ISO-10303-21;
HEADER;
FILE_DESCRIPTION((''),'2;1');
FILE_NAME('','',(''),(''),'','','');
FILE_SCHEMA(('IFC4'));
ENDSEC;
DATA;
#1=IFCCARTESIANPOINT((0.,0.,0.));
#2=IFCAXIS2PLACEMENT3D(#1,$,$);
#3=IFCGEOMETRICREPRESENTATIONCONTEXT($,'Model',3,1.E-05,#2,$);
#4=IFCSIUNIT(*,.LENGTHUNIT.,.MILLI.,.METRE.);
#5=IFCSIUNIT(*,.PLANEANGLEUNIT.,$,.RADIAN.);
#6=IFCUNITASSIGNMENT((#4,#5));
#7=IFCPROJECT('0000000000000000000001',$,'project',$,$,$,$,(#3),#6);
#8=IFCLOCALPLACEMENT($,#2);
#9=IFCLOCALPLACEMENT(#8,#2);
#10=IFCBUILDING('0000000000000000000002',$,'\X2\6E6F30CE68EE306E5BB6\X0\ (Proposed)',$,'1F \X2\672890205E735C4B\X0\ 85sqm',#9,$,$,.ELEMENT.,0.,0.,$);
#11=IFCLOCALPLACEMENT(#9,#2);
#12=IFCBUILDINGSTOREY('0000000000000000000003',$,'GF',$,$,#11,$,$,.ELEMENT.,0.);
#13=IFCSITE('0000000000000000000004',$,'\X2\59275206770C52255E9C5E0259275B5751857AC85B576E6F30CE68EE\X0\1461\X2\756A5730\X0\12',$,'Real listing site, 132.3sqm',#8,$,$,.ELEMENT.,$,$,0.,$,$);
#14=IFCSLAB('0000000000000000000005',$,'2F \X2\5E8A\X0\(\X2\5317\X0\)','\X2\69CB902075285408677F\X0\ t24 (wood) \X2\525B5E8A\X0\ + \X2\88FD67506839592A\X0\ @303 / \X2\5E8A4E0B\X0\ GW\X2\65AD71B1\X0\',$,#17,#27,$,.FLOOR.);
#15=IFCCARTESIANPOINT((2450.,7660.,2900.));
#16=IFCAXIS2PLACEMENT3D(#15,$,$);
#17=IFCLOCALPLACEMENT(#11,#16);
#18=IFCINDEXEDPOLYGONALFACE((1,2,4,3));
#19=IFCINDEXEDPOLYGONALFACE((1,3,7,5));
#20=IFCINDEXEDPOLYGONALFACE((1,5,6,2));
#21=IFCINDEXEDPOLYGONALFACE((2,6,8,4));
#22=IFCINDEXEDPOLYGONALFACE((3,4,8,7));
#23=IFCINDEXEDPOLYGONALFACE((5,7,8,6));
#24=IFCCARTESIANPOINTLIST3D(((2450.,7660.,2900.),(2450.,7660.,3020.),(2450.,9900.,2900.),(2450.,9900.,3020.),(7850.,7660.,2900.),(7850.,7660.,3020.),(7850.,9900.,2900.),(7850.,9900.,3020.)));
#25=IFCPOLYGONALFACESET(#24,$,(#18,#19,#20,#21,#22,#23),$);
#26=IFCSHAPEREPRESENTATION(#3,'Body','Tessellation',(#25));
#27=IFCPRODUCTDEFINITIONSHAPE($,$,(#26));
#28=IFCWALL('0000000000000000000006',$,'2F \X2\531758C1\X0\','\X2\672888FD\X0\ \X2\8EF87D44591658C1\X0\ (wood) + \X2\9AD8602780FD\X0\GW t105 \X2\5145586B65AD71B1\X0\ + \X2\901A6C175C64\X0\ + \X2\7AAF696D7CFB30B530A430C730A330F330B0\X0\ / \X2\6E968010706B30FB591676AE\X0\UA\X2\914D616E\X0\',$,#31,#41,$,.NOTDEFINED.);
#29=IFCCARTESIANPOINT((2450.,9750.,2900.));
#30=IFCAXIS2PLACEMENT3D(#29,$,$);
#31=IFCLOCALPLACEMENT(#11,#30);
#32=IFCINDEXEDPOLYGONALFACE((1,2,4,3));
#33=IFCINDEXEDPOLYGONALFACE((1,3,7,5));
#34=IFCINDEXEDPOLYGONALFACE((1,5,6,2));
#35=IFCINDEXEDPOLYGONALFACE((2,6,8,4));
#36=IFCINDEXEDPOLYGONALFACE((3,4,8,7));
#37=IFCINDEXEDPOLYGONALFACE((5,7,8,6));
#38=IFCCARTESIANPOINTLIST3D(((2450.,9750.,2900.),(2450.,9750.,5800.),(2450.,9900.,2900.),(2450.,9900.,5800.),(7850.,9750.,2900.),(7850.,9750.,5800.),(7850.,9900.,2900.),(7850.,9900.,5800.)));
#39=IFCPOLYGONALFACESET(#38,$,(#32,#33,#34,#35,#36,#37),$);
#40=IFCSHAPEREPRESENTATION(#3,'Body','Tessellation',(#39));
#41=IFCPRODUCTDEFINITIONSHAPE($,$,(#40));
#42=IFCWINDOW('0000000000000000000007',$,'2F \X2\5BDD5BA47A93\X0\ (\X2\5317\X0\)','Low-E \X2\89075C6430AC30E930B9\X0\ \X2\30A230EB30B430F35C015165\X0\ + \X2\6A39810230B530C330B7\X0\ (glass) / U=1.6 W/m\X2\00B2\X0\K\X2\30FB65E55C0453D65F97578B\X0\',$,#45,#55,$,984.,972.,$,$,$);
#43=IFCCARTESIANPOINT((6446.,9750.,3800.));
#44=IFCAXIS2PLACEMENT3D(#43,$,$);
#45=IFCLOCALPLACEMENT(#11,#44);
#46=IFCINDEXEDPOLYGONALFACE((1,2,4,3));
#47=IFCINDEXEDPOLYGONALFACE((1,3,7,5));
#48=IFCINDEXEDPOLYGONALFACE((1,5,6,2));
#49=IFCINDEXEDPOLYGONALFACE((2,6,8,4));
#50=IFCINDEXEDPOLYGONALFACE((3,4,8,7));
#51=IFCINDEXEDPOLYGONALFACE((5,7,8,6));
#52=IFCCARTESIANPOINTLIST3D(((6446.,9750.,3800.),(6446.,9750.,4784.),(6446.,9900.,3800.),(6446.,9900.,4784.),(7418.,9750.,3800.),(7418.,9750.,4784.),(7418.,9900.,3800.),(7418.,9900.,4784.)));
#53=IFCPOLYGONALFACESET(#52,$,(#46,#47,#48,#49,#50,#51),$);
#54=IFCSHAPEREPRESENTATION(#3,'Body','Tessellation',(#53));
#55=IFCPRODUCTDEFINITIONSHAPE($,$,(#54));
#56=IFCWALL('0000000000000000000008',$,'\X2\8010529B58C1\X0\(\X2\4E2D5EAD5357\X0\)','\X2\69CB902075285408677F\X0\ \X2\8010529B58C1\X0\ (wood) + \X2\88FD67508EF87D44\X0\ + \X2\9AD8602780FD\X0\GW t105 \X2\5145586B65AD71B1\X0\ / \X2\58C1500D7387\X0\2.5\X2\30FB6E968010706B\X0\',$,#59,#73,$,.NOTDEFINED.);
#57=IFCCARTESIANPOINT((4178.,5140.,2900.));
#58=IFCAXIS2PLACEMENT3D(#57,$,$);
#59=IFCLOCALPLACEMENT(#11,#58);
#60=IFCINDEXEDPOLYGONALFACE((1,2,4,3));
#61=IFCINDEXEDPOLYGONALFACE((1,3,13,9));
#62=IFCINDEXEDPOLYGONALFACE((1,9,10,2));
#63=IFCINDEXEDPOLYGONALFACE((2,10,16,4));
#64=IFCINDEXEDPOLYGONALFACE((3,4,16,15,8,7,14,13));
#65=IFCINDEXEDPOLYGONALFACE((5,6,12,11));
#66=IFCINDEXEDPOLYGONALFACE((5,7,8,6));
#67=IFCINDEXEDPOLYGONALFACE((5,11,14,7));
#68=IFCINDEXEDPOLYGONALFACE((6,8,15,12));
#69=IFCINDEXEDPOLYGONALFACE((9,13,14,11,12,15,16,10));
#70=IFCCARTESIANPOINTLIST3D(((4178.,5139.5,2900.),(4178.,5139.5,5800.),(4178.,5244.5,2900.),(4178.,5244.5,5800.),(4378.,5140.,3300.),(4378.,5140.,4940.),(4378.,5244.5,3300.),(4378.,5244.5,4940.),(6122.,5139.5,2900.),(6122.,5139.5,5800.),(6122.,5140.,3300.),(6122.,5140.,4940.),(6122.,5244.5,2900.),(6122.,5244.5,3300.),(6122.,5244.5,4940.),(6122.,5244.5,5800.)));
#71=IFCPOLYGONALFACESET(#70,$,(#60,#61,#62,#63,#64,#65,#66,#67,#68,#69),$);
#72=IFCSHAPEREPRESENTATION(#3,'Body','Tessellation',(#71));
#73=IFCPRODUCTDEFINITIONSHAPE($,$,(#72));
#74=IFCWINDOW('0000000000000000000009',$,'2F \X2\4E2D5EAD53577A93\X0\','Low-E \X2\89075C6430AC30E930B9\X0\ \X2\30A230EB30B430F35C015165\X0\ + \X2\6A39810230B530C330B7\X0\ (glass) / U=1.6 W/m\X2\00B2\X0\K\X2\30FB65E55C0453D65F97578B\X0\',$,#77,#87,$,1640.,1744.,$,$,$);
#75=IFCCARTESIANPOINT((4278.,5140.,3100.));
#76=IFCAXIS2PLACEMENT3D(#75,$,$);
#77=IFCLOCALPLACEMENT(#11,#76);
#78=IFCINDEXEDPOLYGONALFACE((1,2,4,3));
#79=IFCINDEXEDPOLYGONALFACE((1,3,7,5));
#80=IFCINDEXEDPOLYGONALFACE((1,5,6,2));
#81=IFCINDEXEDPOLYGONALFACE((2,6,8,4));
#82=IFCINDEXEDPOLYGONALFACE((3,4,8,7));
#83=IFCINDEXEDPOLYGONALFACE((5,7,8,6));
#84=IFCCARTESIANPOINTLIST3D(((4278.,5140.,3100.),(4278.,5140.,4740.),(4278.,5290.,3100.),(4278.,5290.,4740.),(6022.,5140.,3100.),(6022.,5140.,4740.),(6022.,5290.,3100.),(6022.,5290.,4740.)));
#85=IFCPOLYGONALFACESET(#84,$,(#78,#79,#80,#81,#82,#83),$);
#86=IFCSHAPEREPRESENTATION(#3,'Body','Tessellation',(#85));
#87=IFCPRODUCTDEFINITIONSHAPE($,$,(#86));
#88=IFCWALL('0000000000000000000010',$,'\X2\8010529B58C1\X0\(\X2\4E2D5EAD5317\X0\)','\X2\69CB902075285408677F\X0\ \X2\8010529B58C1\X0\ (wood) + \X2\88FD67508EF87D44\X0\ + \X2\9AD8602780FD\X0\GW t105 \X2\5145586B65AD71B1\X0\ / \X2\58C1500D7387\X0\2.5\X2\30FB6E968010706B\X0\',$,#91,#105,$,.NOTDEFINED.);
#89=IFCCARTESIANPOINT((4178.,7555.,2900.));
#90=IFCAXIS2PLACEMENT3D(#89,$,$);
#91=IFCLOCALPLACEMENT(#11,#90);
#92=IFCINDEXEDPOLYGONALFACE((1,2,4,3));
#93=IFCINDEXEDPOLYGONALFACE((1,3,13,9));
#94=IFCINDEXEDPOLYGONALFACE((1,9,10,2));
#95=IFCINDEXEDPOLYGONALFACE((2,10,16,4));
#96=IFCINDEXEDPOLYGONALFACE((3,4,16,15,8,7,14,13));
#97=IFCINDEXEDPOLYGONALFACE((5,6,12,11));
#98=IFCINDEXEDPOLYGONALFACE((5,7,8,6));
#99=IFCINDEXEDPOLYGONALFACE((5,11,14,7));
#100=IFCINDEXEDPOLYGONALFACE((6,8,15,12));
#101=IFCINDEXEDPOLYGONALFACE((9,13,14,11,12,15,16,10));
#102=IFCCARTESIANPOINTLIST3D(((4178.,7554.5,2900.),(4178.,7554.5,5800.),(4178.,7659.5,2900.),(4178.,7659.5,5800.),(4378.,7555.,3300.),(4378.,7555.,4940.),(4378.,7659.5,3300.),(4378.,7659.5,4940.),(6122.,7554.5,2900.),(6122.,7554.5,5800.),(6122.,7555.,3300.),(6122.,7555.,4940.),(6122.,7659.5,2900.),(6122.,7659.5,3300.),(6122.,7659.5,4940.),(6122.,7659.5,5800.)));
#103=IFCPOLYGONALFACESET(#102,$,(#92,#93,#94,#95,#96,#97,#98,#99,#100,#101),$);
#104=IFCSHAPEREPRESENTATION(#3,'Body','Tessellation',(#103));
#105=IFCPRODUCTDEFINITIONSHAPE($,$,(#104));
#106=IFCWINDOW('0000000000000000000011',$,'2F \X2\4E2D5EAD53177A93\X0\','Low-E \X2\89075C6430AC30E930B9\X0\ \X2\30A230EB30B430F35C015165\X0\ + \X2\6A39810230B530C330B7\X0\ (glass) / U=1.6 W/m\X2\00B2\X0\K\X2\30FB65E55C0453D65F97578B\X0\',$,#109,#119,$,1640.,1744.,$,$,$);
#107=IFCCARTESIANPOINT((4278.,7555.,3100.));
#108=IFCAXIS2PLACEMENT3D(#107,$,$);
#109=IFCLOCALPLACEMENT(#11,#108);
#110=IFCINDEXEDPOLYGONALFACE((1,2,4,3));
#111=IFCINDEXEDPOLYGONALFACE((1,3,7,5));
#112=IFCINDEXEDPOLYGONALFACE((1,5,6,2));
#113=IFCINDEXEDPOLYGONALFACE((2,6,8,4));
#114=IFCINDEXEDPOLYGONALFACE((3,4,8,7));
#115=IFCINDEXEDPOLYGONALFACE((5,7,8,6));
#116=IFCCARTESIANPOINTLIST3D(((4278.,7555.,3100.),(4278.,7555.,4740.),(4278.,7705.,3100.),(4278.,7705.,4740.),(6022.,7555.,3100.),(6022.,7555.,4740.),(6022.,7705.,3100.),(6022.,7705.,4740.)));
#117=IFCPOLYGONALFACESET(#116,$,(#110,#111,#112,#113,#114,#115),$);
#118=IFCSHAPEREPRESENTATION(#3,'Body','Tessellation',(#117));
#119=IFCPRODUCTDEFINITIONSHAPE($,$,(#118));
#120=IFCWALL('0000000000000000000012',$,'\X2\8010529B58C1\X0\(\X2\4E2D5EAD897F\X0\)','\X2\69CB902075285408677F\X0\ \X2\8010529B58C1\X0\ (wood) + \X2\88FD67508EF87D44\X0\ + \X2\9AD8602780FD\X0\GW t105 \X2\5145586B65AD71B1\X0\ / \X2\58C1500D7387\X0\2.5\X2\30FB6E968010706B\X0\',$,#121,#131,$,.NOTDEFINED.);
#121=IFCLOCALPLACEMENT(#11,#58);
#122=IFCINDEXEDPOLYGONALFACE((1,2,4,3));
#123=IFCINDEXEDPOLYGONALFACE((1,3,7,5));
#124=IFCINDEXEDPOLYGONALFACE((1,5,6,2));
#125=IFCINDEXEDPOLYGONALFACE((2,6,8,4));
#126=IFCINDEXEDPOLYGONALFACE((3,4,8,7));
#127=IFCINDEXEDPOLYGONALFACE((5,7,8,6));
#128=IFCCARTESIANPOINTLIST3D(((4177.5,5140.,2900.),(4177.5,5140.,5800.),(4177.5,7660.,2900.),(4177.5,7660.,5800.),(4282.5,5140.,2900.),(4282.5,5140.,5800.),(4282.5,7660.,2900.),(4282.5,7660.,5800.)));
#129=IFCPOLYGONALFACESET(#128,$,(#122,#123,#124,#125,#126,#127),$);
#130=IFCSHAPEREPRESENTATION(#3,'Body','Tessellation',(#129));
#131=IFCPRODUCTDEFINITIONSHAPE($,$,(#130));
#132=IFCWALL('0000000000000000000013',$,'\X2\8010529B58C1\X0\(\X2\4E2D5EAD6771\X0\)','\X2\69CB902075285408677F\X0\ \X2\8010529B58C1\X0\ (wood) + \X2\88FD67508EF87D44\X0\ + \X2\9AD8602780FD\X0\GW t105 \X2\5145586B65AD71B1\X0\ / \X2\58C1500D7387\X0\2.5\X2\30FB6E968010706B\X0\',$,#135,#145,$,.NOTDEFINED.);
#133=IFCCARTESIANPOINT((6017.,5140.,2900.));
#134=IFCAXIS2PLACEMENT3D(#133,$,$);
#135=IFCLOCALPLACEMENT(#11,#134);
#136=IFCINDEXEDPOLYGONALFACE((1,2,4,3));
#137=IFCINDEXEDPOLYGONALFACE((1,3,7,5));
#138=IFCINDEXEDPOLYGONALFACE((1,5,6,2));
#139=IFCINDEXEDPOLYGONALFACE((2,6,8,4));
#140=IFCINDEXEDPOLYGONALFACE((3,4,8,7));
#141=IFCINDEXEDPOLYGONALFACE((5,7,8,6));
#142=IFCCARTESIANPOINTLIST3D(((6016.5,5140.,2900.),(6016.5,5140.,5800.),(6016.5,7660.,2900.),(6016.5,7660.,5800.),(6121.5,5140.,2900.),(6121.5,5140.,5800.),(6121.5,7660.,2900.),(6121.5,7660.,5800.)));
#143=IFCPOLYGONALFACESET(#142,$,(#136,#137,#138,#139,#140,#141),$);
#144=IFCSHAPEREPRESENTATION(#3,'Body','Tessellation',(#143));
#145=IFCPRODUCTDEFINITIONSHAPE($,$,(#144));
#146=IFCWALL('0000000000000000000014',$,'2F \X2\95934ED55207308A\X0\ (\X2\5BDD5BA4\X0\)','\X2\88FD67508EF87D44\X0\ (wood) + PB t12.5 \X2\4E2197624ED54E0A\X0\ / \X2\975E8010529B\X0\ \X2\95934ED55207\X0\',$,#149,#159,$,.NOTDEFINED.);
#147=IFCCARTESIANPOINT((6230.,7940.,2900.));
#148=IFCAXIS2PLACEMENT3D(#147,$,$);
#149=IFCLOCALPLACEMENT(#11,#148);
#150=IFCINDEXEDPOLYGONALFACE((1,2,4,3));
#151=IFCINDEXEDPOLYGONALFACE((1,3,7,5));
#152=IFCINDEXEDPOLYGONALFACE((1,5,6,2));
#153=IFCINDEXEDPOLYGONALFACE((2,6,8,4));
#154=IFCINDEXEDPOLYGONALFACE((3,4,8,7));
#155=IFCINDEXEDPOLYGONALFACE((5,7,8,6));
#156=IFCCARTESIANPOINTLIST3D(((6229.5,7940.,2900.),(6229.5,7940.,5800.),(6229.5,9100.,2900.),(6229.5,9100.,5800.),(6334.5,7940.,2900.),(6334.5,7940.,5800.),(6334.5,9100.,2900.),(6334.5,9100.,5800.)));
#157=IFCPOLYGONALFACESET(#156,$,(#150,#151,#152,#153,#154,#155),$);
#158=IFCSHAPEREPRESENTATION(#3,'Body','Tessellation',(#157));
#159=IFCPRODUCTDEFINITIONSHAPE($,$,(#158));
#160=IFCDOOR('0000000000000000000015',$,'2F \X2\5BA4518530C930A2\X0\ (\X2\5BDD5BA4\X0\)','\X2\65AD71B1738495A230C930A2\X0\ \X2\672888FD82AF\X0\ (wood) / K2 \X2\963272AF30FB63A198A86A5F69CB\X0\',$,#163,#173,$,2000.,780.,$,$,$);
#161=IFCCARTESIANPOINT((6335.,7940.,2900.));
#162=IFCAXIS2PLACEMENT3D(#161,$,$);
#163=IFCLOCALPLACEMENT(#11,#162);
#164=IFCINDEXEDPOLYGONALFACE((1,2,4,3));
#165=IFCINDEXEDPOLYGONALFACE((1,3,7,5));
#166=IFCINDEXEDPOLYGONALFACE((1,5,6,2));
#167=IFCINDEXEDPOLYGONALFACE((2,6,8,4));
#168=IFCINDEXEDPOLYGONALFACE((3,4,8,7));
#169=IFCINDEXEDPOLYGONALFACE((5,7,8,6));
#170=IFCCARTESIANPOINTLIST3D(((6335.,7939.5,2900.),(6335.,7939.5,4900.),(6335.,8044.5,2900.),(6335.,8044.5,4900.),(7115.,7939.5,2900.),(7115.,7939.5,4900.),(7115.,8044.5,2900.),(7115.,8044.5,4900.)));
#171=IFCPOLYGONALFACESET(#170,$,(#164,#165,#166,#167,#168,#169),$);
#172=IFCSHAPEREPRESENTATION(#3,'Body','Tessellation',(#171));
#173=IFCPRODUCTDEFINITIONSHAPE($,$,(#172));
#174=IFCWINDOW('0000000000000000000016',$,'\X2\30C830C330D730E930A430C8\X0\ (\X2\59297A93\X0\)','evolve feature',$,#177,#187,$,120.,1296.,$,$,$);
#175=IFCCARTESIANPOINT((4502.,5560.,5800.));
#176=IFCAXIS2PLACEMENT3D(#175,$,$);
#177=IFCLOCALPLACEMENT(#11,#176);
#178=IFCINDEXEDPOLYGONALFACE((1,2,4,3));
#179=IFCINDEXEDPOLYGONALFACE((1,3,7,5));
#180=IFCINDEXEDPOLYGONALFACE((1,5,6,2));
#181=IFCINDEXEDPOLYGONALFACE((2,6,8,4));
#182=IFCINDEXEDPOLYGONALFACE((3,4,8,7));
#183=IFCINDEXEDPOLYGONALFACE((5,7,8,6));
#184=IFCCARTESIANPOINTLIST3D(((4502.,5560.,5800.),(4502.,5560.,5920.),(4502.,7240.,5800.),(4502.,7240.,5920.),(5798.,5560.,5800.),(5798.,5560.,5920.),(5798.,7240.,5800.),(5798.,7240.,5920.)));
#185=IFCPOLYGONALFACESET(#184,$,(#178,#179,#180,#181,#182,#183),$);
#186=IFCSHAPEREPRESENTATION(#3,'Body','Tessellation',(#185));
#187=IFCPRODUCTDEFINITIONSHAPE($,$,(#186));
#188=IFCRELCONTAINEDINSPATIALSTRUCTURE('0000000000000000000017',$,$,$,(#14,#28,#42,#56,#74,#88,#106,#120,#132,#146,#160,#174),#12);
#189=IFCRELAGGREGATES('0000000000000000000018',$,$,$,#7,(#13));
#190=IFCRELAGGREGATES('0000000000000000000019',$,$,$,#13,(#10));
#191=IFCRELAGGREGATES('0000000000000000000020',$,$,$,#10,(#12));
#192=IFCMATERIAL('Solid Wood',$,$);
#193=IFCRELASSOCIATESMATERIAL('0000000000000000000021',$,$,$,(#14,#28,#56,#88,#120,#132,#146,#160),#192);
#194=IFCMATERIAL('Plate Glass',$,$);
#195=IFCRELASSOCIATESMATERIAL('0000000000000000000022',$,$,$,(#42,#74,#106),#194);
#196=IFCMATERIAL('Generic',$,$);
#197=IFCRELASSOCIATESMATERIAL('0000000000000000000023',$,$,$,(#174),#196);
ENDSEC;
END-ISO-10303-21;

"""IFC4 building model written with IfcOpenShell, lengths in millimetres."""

from ifc_helpers import new_model, si_unit, frame, frame_2d, origin, place, context, project, spatial, rectangle, extrude, material, element, fill, save


model = new_model("IFC4")

# Units and contexts
model_context = context("Model", 3, precision=1e-05, world=origin())
ifc_project = project(units=[si_unit("LENGTHUNIT", "METRE", prefix="MILLI"), si_unit("PLANEANGLEUNIT", "RADIAN")], contexts=[model_context])

# Site, building, storey
site_placement = place(None, origin())
site = spatial("IfcSite", under=ifc_project, at=site_placement, Name="大分県別府市大字内竈字湯ノ森1461番地12", ObjectType="Real listing site, 132.3sqm", CompositionType="ELEMENT", RefElevation=0.0)
building_placement = place(site_placement, origin())
building = spatial("IfcBuilding", under=site, at=building_placement, Name="湯ノ森の家 (Proposed)", ObjectType="1F 木造平屋 85sqm", CompositionType="ELEMENT", ElevationOfRefHeight=0.0, ElevationOfTerrain=0.0)
storey_placement = place(building_placement, origin())
storey = spatial("IfcBuildingStorey", under=building, at=storey_placement, Name="GF", CompositionType="ELEMENT", Elevation=0.0)

# Slab
ifc_material_1 = material(Name="Solid Wood")
slab_placement = place(storey_placement, frame((2450.0, 7660.0, 2900.0)))
element("IfcSlab", 1, at=slab_placement, inside=storey, material=ifc_material_1, Name="2F 床(北)", Description="構造用合板 t24 (wood) 剛床 + 製材根太 @303 / 床下 GW断熱", PredefinedType="FLOOR", context=model_context, shape_type="SweptSolid", body=[
    extrude(rectangle(XDim=5400.0, YDim=2240.0, at=frame_2d((2700.0, 1120.0))), frame((2450.0, 7660.0, 2900.0)), (0.0, 0.0, 1.0), 120.0),
])

# Walls, openings, windows
wall_1_placement = place(storey_placement, frame((2450.0, 9750.0, 2900.0)))
wall_1 = element("IfcWall", 2, at=wall_1_placement, inside=storey, material=ifc_material_1, Name="2F 北壁", Description="木製 軸組外壁 (wood) + 高性能GW t105 充填断熱 + 通気層 + 窯業系サイディング / 準耐火・外皮UA配慮", PredefinedType="NOTDEFINED", context=model_context, shape_type="SweptSolid", body=[
    extrude(rectangle(XDim=5400.0, YDim=150.0, at=frame_2d((2700.0, 75.0))), frame((2450.0, 9750.0, 2900.0)), (0.0, 0.0, 1.0), 2900.0),
])
opening_1_placement = place(storey_placement, frame((6446.0, 9750.0, 3800.0)))
opening_1 = element("IfcOpeningElement", 3, at=opening_1_placement, cuts=wall_1, PredefinedType="NOTDEFINED", context=model_context, shape_type="SweptSolid", body=[
    extrude(rectangle(XDim=972.0, YDim=150.0, at=frame_2d((486.0, 75.0))), frame((6446.0, 9750.0, 3800.0)), (0.0, 0.0, 1.0), 984.0),
])
ifc_material_2 = material(Name="Plate Glass")
window_1_placement = place(storey_placement, frame((6446.0, 9750.0, 3800.0)))
window_1 = element("IfcWindow", 4, at=window_1_placement, inside=storey, material=ifc_material_2, Name="2F 寝室窓 (北)", Description="Low-E 複層ガラス アルゴン封入 + 樹脂サッシ (glass) / U=1.6 W/m²K・日射取得型", OverallHeight=984.0, OverallWidth=972.0, context=model_context, shape_type="SweptSolid", body=[
    extrude(rectangle(XDim=972.0, YDim=150.0, at=frame_2d((486.0, 75.0))), frame((6446.0, 9750.0, 3800.0)), (0.0, 0.0, 1.0), 984.0),
])
fill(opening_1, window_1)
wall_2_placement = place(storey_placement, frame((4178.0, 5140.0, 2900.0)))
wall_2 = element("IfcWall", 5, at=wall_2_placement, inside=storey, material=ifc_material_1, Name="耐力壁(中庭南)", Description="構造用合板 耐力壁 (wood) + 製材軸組 + 高性能GW t105 充填断熱 / 壁倍率2.5・準耐火", PredefinedType="NOTDEFINED", context=model_context, shape_type="SweptSolid", body=[
    extrude(rectangle(XDim=1944.0, YDim=105.0, at=frame_2d((972.0, 52.0))), frame((4178.0, 5140.0, 2900.0)), (0.0, 0.0, 1.0), 2900.0),
])
opening_2_placement = place(storey_placement, frame((4278.0, 5140.0, 3100.0)))
opening_2 = element("IfcOpeningElement", 6, at=opening_2_placement, cuts=wall_2, PredefinedType="NOTDEFINED", context=model_context, shape_type="SweptSolid", body=[
    extrude(rectangle(XDim=1744.0, YDim=150.0, at=frame_2d((872.0, 75.0))), frame((4278.0, 5140.0, 3100.0)), (0.0, 0.0, 1.0), 1640.0),
])
window_2_placement = place(storey_placement, frame((4278.0, 5140.0, 3100.0)))
window_2 = element("IfcWindow", 7, at=window_2_placement, inside=storey, material=ifc_material_2, Name="2F 中庭南窓", Description="Low-E 複層ガラス アルゴン封入 + 樹脂サッシ (glass) / U=1.6 W/m²K・日射取得型", OverallHeight=1640.0, OverallWidth=1744.0, context=model_context, shape_type="SweptSolid", body=[
    extrude(rectangle(XDim=1744.0, YDim=150.0, at=frame_2d((872.0, 75.0))), frame((4278.0, 5140.0, 3100.0)), (0.0, 0.0, 1.0), 1640.0),
])
fill(opening_2, window_2)
wall_3_placement = place(storey_placement, frame((4178.0, 7555.0, 2900.0)))
wall_3 = element("IfcWall", 8, at=wall_3_placement, inside=storey, material=ifc_material_1, Name="耐力壁(中庭北)", Description="構造用合板 耐力壁 (wood) + 製材軸組 + 高性能GW t105 充填断熱 / 壁倍率2.5・準耐火", PredefinedType="NOTDEFINED", context=model_context, shape_type="SweptSolid", body=[
    extrude(rectangle(XDim=1944.0, YDim=105.0, at=frame_2d((972.0, 52.0))), frame((4178.0, 7555.0, 2900.0)), (0.0, 0.0, 1.0), 2900.0),
])
opening_3_placement = place(storey_placement, frame((4278.0, 7555.0, 3100.0)))
opening_3 = element("IfcOpeningElement", 9, at=opening_3_placement, cuts=wall_3, PredefinedType="NOTDEFINED", context=model_context, shape_type="SweptSolid", body=[
    extrude(rectangle(XDim=1744.0, YDim=150.0, at=frame_2d((872.0, 75.0))), frame((4278.0, 7555.0, 3100.0)), (0.0, 0.0, 1.0), 1640.0),
])
window_3_placement = place(storey_placement, frame((4278.0, 7555.0, 3100.0)))
window_3 = element("IfcWindow", 10, at=window_3_placement, inside=storey, material=ifc_material_2, Name="2F 中庭北窓", Description="Low-E 複層ガラス アルゴン封入 + 樹脂サッシ (glass) / U=1.6 W/m²K・日射取得型", OverallHeight=1640.0, OverallWidth=1744.0, context=model_context, shape_type="SweptSolid", body=[
    extrude(rectangle(XDim=1744.0, YDim=150.0, at=frame_2d((872.0, 75.0))), frame((4278.0, 7555.0, 3100.0)), (0.0, 0.0, 1.0), 1640.0),
])
fill(opening_3, window_3)

# Walls
wall_4_placement = place(storey_placement, frame((4178.0, 5140.0, 2900.0)))
element("IfcWall", 11, at=wall_4_placement, inside=storey, material=ifc_material_1, Name="耐力壁(中庭西)", Description="構造用合板 耐力壁 (wood) + 製材軸組 + 高性能GW t105 充填断熱 / 壁倍率2.5・準耐火", PredefinedType="NOTDEFINED", context=model_context, shape_type="SweptSolid", body=[
    extrude(rectangle(XDim=105.0, YDim=2520.0, at=frame_2d((52.0, 1260.0))), frame((4178.0, 5140.0, 2900.0)), (0.0, 0.0, 1.0), 2900.0),
])
wall_5_placement = place(storey_placement, frame((6017.0, 5140.0, 2900.0)))
element("IfcWall", 12, at=wall_5_placement, inside=storey, material=ifc_material_1, Name="耐力壁(中庭東)", Description="構造用合板 耐力壁 (wood) + 製材軸組 + 高性能GW t105 充填断熱 / 壁倍率2.5・準耐火", PredefinedType="NOTDEFINED", context=model_context, shape_type="SweptSolid", body=[
    extrude(rectangle(XDim=105.0, YDim=2520.0, at=frame_2d((52.0, 1260.0))), frame((6017.0, 5140.0, 2900.0)), (0.0, 0.0, 1.0), 2900.0),
])
wall_6_placement = place(storey_placement, frame((6230.0, 7940.0, 2900.0)))
element("IfcWall", 13, at=wall_6_placement, inside=storey, material=ifc_material_1, Name="2F 間仕切り (寝室)", Description="製材軸組 (wood) + PB t12.5 両面仕上 / 非耐力 間仕切", PredefinedType="NOTDEFINED", context=model_context, shape_type="SweptSolid", body=[
    extrude(rectangle(XDim=105.0, YDim=1160.0, at=frame_2d((52.0, 580.0))), frame((6230.0, 7940.0, 2900.0)), (0.0, 0.0, 1.0), 2900.0),
])

# Door
door_placement = place(storey_placement, frame((6335.0, 7940.0, 2900.0)))
element("IfcDoor", 14, at=door_placement, inside=storey, material=ifc_material_1, Name="2F 室内ドア (寝室)", Description="断熱玄関ドア 木製芯 (wood) / K2 防犯・採風機構", OverallHeight=2000.0, OverallWidth=780.0, context=model_context, shape_type="SweptSolid", body=[
    extrude(rectangle(XDim=780.0, YDim=105.0, at=frame_2d((390.0, 52.0))), frame((6335.0, 7940.0, 2900.0)), (0.0, 0.0, 1.0), 2000.0),
])

# Window
ifc_material_3 = material(Name="Generic")
window_4_placement = place(storey_placement, frame((4502.0, 5560.0, 5800.0)))
element("IfcWindow", 15, at=window_4_placement, inside=storey, material=ifc_material_3, Name="トップライト (天窓)", Description="evolve feature", OverallHeight=120.0, OverallWidth=1296.0, context=model_context, shape_type="SweptSolid", body=[
    extrude(rectangle(XDim=1296.0, YDim=1680.0, at=frame_2d((648.0, 840.0))), frame((4502.0, 5560.0, 5800.0)), (0.0, 0.0, 1.0), 120.0),
])

save(model, "model.ifc")
